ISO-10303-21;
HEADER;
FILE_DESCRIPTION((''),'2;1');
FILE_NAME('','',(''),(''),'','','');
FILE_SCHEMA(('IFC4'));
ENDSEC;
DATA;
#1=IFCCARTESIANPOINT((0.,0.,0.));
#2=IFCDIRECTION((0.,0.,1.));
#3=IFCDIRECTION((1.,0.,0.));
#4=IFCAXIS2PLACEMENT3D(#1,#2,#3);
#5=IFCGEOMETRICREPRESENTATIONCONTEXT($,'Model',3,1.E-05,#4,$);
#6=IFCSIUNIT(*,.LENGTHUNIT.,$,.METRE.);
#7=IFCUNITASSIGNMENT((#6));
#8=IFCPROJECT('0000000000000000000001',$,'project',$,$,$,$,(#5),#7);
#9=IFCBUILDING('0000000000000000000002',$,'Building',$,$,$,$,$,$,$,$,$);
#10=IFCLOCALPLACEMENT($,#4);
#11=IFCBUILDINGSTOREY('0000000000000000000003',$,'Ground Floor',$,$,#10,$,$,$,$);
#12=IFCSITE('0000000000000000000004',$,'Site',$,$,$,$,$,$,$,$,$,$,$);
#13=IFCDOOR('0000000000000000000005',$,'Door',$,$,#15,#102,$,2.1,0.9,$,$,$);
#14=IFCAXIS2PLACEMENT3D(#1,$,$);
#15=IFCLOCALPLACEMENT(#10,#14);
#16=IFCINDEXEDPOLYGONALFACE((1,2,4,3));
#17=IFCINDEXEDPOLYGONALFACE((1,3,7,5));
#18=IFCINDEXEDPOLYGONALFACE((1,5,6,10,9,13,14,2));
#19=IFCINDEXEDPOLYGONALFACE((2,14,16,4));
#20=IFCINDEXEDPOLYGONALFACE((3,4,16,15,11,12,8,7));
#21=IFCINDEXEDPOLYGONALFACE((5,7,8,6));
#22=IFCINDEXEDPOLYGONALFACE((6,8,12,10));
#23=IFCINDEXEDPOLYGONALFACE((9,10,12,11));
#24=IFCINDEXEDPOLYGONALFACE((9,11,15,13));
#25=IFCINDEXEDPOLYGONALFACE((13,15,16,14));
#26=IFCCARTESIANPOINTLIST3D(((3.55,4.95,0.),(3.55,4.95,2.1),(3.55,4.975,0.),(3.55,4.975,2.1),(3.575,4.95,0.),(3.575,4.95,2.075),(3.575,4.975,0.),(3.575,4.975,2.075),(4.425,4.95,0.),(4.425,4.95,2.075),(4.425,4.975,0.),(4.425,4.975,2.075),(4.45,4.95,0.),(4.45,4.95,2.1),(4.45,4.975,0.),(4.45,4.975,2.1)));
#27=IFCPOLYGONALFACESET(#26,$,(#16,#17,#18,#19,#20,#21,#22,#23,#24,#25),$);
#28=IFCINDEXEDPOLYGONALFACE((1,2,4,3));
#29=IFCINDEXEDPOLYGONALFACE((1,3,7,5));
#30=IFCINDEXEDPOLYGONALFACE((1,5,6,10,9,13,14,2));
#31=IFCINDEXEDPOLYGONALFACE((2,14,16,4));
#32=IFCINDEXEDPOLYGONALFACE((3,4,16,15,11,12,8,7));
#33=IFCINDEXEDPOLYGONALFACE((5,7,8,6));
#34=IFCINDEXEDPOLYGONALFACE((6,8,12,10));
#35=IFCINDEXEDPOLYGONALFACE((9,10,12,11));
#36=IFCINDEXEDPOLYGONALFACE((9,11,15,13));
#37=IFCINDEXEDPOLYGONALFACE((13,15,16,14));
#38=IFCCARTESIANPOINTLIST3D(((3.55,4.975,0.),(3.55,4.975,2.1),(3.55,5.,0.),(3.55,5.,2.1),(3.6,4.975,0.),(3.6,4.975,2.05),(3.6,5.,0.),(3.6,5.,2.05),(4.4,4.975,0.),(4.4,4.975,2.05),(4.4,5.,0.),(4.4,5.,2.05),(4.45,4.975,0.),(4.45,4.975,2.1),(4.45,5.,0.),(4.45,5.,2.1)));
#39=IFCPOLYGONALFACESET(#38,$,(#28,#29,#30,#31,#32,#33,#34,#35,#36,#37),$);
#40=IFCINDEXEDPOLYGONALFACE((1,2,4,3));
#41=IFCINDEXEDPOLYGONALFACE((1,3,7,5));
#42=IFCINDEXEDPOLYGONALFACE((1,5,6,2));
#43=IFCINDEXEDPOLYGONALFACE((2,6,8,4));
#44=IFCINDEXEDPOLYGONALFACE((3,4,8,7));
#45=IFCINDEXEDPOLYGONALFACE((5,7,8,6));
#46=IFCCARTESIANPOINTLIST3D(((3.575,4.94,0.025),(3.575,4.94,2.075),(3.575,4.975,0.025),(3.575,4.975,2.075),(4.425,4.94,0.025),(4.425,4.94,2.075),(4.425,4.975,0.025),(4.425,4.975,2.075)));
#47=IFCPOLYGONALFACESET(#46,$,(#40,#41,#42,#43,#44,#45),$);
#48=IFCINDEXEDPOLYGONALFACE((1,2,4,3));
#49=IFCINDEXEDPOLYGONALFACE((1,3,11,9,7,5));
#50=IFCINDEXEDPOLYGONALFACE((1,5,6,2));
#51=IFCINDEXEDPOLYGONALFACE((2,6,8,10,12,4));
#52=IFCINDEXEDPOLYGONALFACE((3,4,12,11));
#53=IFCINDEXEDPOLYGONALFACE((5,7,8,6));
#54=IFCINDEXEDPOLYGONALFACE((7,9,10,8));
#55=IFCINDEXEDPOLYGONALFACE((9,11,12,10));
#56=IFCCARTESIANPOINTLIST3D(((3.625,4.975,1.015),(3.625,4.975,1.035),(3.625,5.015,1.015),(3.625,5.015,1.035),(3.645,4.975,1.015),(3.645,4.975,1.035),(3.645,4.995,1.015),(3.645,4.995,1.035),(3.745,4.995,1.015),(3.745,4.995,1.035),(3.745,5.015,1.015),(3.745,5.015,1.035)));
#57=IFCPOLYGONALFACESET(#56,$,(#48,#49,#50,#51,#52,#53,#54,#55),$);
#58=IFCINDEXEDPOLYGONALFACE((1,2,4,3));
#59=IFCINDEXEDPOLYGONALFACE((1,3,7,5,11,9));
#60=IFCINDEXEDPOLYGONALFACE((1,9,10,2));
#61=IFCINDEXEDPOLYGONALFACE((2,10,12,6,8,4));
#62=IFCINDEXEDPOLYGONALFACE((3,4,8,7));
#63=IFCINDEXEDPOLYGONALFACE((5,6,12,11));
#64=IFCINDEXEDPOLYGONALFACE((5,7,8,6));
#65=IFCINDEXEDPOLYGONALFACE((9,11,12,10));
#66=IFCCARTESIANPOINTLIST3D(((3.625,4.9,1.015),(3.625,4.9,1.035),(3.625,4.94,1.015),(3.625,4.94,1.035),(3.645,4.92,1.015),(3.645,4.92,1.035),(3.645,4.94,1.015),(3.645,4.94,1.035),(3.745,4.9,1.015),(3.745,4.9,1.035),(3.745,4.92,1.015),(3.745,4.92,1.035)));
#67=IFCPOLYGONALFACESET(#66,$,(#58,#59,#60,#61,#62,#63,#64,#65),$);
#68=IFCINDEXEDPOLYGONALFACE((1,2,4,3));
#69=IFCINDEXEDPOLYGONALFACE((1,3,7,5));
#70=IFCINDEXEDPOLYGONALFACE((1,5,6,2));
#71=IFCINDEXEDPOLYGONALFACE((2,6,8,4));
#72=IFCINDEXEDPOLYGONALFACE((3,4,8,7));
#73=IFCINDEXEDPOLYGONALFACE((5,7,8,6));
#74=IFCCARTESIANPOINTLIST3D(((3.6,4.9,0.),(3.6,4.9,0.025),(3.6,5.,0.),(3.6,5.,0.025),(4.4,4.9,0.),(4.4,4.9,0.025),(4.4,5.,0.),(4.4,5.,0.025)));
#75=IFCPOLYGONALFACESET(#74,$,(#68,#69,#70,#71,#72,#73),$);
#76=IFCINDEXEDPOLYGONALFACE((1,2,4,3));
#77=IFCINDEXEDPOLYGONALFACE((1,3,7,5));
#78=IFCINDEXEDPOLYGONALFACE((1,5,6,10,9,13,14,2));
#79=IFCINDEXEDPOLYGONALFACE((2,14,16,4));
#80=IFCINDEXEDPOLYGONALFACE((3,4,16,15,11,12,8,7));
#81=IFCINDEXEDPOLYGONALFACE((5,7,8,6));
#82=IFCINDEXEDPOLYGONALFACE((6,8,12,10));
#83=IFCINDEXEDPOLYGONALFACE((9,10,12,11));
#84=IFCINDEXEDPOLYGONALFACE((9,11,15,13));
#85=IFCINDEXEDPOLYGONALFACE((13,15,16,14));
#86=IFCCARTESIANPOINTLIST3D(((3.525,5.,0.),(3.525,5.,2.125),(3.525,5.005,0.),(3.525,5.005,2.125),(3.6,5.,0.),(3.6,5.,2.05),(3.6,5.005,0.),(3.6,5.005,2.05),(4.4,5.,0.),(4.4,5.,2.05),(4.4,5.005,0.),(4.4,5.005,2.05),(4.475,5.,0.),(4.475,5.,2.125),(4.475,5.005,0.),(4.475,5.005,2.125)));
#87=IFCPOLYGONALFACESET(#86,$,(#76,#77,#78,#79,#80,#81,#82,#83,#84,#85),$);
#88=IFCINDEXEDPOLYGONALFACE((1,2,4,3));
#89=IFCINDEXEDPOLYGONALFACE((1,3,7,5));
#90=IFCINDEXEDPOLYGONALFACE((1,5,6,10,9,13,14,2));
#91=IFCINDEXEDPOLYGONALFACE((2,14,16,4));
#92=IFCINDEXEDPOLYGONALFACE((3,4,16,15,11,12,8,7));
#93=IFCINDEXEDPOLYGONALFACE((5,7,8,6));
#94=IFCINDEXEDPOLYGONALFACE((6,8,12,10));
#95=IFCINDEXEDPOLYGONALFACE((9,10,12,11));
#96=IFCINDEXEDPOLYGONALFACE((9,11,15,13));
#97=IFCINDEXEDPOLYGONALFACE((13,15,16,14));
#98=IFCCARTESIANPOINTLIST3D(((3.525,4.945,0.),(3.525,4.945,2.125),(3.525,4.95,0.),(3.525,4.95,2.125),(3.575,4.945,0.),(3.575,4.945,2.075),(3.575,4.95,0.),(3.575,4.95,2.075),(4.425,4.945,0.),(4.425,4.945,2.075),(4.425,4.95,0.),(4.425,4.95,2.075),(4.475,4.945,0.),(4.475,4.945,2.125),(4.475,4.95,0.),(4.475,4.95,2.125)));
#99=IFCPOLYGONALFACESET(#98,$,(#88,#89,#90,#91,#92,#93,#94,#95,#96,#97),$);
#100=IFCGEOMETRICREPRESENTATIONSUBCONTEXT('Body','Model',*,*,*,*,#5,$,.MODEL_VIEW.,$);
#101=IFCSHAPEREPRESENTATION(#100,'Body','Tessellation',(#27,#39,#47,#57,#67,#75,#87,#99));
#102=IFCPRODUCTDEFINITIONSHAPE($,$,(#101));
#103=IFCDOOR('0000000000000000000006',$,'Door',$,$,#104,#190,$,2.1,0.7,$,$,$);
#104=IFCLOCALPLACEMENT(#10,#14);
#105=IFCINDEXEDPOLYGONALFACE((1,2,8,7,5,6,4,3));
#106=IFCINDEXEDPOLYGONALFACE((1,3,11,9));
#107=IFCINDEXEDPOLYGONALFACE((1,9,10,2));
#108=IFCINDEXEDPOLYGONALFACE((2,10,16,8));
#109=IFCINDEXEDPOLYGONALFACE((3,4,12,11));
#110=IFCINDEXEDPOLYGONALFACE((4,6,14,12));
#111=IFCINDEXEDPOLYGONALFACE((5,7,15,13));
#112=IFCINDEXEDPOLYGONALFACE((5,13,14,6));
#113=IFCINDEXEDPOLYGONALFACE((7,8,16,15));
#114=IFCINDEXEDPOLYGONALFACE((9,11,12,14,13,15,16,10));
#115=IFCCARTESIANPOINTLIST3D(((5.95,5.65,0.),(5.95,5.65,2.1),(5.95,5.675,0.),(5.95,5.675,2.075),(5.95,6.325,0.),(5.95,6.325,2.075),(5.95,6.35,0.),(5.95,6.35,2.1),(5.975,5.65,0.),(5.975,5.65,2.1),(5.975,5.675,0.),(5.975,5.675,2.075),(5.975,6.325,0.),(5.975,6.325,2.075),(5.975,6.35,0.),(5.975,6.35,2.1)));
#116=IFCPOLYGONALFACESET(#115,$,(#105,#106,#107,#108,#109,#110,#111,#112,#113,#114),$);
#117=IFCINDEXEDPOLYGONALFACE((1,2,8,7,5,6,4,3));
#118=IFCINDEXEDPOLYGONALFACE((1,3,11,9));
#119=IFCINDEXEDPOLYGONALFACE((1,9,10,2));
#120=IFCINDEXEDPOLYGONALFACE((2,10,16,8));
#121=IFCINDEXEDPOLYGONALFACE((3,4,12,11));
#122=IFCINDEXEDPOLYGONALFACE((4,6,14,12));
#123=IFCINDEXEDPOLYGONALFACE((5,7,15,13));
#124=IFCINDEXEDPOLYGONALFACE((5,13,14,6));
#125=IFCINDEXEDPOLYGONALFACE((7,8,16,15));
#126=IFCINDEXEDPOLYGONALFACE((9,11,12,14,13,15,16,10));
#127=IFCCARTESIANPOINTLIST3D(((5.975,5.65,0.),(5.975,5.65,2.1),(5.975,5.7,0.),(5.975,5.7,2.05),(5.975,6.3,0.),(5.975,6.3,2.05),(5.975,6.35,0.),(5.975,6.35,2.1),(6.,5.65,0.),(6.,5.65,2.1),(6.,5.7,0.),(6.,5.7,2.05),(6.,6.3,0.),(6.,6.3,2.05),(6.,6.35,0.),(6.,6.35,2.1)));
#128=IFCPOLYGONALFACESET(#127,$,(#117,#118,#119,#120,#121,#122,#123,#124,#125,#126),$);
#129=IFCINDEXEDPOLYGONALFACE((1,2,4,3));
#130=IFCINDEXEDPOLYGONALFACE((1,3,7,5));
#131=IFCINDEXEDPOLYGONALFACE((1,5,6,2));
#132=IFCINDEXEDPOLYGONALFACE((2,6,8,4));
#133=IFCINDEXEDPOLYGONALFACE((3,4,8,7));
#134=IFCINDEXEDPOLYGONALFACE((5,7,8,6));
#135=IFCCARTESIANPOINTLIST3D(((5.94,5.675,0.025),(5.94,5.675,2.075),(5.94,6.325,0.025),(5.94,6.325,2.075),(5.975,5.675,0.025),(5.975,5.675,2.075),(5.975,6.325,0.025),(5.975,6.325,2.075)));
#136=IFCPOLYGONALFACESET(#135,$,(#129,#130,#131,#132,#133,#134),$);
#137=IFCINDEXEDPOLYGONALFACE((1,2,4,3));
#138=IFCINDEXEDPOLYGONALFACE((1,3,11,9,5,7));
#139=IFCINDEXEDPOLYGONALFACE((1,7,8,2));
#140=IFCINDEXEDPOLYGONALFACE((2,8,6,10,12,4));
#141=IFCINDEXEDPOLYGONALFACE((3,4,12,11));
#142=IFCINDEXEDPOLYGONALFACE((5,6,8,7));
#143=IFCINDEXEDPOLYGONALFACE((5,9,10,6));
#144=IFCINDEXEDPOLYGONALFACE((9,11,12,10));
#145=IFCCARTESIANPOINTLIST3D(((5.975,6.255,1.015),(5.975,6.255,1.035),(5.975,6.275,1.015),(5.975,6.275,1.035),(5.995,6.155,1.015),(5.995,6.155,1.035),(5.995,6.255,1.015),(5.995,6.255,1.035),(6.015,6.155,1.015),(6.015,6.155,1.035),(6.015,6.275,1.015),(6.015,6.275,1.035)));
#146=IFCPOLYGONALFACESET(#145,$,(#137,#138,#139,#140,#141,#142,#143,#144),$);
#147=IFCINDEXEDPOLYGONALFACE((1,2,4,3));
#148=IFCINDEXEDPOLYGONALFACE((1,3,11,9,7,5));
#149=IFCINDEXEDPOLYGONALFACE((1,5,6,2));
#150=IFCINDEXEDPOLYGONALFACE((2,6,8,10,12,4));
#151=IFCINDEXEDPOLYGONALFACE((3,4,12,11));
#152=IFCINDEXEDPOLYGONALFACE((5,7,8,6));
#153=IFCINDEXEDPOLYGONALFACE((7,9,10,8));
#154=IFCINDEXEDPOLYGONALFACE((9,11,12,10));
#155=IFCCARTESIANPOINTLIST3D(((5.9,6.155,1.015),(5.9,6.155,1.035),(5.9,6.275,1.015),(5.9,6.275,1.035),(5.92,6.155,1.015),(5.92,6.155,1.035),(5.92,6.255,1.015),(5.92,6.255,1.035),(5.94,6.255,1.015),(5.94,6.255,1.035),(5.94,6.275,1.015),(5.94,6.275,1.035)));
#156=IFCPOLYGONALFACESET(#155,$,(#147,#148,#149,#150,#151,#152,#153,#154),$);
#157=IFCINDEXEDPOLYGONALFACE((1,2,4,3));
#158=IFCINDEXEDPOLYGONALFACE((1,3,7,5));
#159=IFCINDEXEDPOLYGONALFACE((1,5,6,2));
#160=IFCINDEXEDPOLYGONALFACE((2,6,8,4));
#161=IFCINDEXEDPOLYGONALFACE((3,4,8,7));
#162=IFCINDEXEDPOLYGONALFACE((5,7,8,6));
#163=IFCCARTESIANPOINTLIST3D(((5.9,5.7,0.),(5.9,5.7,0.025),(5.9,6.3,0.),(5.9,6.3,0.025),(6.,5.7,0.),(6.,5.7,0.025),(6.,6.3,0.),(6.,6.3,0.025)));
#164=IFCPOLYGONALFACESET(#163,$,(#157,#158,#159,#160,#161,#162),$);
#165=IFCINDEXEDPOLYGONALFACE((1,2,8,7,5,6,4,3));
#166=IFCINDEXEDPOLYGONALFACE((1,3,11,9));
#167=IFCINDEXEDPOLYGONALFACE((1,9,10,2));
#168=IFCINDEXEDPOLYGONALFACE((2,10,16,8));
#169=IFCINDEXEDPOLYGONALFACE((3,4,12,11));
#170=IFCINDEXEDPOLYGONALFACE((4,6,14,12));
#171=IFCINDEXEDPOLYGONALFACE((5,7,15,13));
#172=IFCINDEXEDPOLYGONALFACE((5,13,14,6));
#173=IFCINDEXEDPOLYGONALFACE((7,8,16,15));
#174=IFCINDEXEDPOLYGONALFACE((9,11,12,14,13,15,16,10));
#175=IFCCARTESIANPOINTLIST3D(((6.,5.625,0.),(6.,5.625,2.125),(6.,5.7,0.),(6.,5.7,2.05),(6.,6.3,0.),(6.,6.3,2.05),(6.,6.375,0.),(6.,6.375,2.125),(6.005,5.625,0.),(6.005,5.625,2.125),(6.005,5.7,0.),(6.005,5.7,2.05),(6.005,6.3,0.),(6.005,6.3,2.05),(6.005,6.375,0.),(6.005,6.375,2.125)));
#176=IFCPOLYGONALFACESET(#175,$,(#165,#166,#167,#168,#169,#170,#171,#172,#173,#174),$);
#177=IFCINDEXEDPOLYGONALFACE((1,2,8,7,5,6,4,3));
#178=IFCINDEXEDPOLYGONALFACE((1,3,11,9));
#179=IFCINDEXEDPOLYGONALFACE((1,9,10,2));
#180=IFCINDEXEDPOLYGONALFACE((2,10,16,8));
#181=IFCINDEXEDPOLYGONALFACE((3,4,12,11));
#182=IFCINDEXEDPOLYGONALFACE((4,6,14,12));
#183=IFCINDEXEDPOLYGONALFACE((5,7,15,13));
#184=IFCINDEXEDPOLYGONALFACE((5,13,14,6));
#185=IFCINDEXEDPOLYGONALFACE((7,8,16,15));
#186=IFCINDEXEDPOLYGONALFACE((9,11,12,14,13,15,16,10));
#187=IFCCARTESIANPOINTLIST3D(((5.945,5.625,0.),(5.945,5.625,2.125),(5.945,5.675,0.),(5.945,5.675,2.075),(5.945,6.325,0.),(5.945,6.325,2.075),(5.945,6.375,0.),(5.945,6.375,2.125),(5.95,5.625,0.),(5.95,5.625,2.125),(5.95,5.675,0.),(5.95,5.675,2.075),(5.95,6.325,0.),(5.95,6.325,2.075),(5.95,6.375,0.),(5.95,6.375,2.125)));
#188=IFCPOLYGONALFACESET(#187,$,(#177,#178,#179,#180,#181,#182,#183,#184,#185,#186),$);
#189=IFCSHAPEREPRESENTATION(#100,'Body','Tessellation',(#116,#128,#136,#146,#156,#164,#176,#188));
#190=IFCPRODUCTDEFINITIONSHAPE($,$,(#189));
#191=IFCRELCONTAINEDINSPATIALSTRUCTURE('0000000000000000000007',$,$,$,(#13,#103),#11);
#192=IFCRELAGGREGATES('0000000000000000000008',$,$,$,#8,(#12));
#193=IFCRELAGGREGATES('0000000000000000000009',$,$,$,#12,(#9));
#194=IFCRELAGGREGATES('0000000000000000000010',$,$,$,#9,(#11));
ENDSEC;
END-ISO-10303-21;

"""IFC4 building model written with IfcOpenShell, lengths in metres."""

from ifc_helpers import new_model, si_unit, frame, origin_with_axes, place, context, subcontext, project, spatial, line, indexed_curve, outline, extrude, element, save


model = new_model("IFC4")

# Units and contexts
model_context = context("Model", 3, precision=1e-05, world=origin_with_axes())
body_context = subcontext(model_context, "Body", "Model", "MODEL_VIEW")
ifc_project = project(units=[si_unit("LENGTHUNIT", "METRE")], contexts=[model_context])

# Site, building, storey
site = spatial("IfcSite", under=ifc_project, Name="Site")
building = spatial("IfcBuilding", under=site, Name="Building")
storey_placement = place(None, origin_with_axes())
storey = spatial("IfcBuildingStorey", under=building, at=storey_placement, Name="Ground Floor")

# Doors
door_1_placement = place(storey_placement, frame((4.45, 5.0, 0.0), z_axis=(0.0, 0.0, 1.0), x_axis=(-1.0, 0.0, 0.0)))
element("IfcDoor", 1, at=door_1_placement, inside=storey, Name="Door", OverallHeight=2.1, OverallWidth=0.9, context=body_context, shape_type="SweptSolid", body=[
    extrude(outline(indexed_curve([(0.0, 0.0), (0.0, 2.1), (0.9, 2.1), (0.9, 0.0), (0.875, 0.0), (0.875, 2.075), (0.025, 2.075), (0.025, 0.0)], segments=[line(1, 2, 3, 4, 5, 6, 7, 8, 1)])), frame((0.0, 0.025, 0.0), z_axis=(0.0, -1.0, 0.0), x_axis=(1.0, 0.0, 0.0)), (0.0, 0.0, -1.0), 0.025),
    extrude(outline(indexed_curve([(0.0, 0.0), (0.0, 2.1), (0.9, 2.1), (0.9, 0.0), (0.85, 0.0), (0.85, 2.05), (0.05, 2.05), (0.05, 0.0)], segments=[line(1, 2, 3, 4, 5, 6, 7, 8, 1)])), frame((0.0, 0.0, 0.0), z_axis=(0.0, -1.0, 0.0), x_axis=(1.0, 0.0, 0.0)), (0.0, 0.0, -1.0), 0.025),
    extrude(outline(indexed_curve([(0.0, 0.0), (0.85, 0.0), (0.85, 0.035), (0.0, 0.035)], segments=[line(1, 2, 3, 4, 1)])), frame((0.025, 0.025, 0.025), z_axis=(0.0, 0.0, 1.0), x_axis=(1.0, 0.0, 0.0)), (0.0, 0.0, 1.0), 2.05),
    extrude(outline(indexed_curve([(0.0, 0.0), (0.0, -0.04), (-0.12, -0.04), (-0.12, -0.02), (-0.02, -0.02), (-0.02, 0.0)], segments=[line(1, 2, 3, 4, 5, 6, 1)])), frame((0.825, 0.025, 1.015), z_axis=(0.0, 0.0, 1.0), x_axis=(1.0, 0.0, 0.0)), (0.0, 0.0, 1.0), 0.02),
    extrude(outline(indexed_curve([(0.0, 0.0), (0.0, 0.04), (-0.12, 0.04), (-0.12, 0.02), (-0.02, 0.02), (-0.02, 0.0)], segments=[line(1, 2, 3, 4, 5, 6, 1)])), frame((0.825, 0.06, 1.015), z_axis=(0.0, 0.0, 1.0), x_axis=(1.0, 0.0, 0.0)), (0.0, 0.0, 1.0), 0.02),
    extrude(outline(indexed_curve([(0.0, 0.0), (0.8, 0.0), (0.8, 0.1), (0.0, 0.1)], segments=[line(1, 2, 3, 4, 1)])), frame((0.05, 0.0, 0.0), z_axis=(0.0, 0.0, 1.0), x_axis=(1.0, 0.0, 0.0)), (0.0, 0.0, 1.0), 0.025),
    extrude(outline(indexed_curve([(0.0, 0.0), (0.0, 2.125), (0.95, 2.125), (0.95, 0.0), (0.875, 0.0), (0.875, 2.05), (0.075, 2.05), (0.075, 0.0)], segments=[line(1, 2, 3, 4, 5, 6, 7, 8, 1)])), frame((-0.025, -0.005, 0.0), z_axis=(0.0, -1.0, 0.0), x_axis=(1.0, 0.0, 0.0)), (0.0, 0.0, -1.0), 0.005),
    extrude(outline(indexed_curve([(0.0, 0.0), (0.0, 2.125), (0.95, 2.125), (0.95, 0.0), (0.9, 0.0), (0.9, 2.075), (0.05, 2.075), (0.05, 0.0)], segments=[line(1, 2, 3, 4, 5, 6, 7, 8, 1)])), frame((-0.025, 0.05, 0.0), z_axis=(0.0, -1.0, 0.0), x_axis=(1.0, 0.0, 0.0)), (0.0, 0.0, -1.0), 0.005),
])
door_2_placement = place(storey_placement, frame((6.0, 5.65, 0.0), z_axis=(0.0, 0.0, 1.0), x_axis=(0.0, 1.0, 0.0)))
element("IfcDoor", 2, at=door_2_placement, inside=storey, Name="Door", OverallHeight=2.1, OverallWidth=0.7, context=body_context, shape_type="SweptSolid", body=[
    extrude(outline(indexed_curve([(0.0, 0.0), (0.0, 2.1), (0.7, 2.1), (0.7, 0.0), (0.675, 0.0), (0.675, 2.075), (0.025, 2.075), (0.025, 0.0)], segments=[line(1, 2, 3, 4, 5, 6, 7, 8, 1)])), frame((0.0, 0.025, 0.0), z_axis=(0.0, -1.0, 0.0), x_axis=(1.0, 0.0, 0.0)), (0.0, 0.0, -1.0), 0.025),
    extrude(outline(indexed_curve([(0.0, 0.0), (0.0, 2.1), (0.7, 2.1), (0.7, 0.0), (0.65, 0.0), (0.65, 2.05), (0.05, 2.05), (0.05, 0.0)], segments=[line(1, 2, 3, 4, 5, 6, 7, 8, 1)])), frame((0.0, 0.0, 0.0), z_axis=(0.0, -1.0, 0.0), x_axis=(1.0, 0.0, 0.0)), (0.0, 0.0, -1.0), 0.025),
    extrude(outline(indexed_curve([(0.0, 0.0), (0.65, 0.0), (0.65, 0.035), (0.0, 0.035)], segments=[line(1, 2, 3, 4, 1)])), frame((0.025, 0.025, 0.025), z_axis=(0.0, 0.0, 1.0), x_axis=(1.0, 0.0, 0.0)), (0.0, 0.0, 1.0), 2.05),
    extrude(outline(indexed_curve([(0.0, 0.0), (0.0, -0.04), (-0.12, -0.04), (-0.12, -0.02), (-0.02, -0.02), (-0.02, 0.0)], segments=[line(1, 2, 3, 4, 5, 6, 1)])), frame((0.625, 0.025, 1.015), z_axis=(0.0, 0.0, 1.0), x_axis=(1.0, 0.0, 0.0)), (0.0, 0.0, 1.0), 0.02),
    extrude(outline(indexed_curve([(0.0, 0.0), (0.0, 0.04), (-0.12, 0.04), (-0.12, 0.02), (-0.02, 0.02), (-0.02, 0.0)], segments=[line(1, 2, 3, 4, 5, 6, 1)])), frame((0.625, 0.06, 1.015), z_axis=(0.0, 0.0, 1.0), x_axis=(1.0, 0.0, 0.0)), (0.0, 0.0, 1.0), 0.02),
    extrude(outline(indexed_curve([(0.0, 0.0), (0.6, 0.0), (0.6, 0.1), (0.0, 0.1)], segments=[line(1, 2, 3, 4, 1)])), frame((0.05, 0.0, 0.0), z_axis=(0.0, 0.0, 1.0), x_axis=(1.0, 0.0, 0.0)), (0.0, 0.0, 1.0), 0.025),
    extrude(outline(indexed_curve([(0.0, 0.0), (0.0, 2.125), (0.75, 2.125), (0.75, 0.0), (0.675, 0.0), (0.675, 2.05), (0.075, 2.05), (0.075, 0.0)], segments=[line(1, 2, 3, 4, 5, 6, 7, 8, 1)])), frame((-0.025, -0.005, 0.0), z_axis=(0.0, -1.0, 0.0), x_axis=(1.0, 0.0, 0.0)), (0.0, 0.0, -1.0), 0.005),
    extrude(outline(indexed_curve([(0.0, 0.0), (0.0, 2.125), (0.75, 2.125), (0.75, 0.0), (0.7, 0.0), (0.7, 2.075), (0.05, 2.075), (0.05, 0.0)], segments=[line(1, 2, 3, 4, 5, 6, 7, 8, 1)])), frame((-0.025, 0.05, 0.0), z_axis=(0.0, -1.0, 0.0), x_axis=(1.0, 0.0, 0.0)), (0.0, 0.0, -1.0), 0.005),
])

save(model, "model.ifc")
